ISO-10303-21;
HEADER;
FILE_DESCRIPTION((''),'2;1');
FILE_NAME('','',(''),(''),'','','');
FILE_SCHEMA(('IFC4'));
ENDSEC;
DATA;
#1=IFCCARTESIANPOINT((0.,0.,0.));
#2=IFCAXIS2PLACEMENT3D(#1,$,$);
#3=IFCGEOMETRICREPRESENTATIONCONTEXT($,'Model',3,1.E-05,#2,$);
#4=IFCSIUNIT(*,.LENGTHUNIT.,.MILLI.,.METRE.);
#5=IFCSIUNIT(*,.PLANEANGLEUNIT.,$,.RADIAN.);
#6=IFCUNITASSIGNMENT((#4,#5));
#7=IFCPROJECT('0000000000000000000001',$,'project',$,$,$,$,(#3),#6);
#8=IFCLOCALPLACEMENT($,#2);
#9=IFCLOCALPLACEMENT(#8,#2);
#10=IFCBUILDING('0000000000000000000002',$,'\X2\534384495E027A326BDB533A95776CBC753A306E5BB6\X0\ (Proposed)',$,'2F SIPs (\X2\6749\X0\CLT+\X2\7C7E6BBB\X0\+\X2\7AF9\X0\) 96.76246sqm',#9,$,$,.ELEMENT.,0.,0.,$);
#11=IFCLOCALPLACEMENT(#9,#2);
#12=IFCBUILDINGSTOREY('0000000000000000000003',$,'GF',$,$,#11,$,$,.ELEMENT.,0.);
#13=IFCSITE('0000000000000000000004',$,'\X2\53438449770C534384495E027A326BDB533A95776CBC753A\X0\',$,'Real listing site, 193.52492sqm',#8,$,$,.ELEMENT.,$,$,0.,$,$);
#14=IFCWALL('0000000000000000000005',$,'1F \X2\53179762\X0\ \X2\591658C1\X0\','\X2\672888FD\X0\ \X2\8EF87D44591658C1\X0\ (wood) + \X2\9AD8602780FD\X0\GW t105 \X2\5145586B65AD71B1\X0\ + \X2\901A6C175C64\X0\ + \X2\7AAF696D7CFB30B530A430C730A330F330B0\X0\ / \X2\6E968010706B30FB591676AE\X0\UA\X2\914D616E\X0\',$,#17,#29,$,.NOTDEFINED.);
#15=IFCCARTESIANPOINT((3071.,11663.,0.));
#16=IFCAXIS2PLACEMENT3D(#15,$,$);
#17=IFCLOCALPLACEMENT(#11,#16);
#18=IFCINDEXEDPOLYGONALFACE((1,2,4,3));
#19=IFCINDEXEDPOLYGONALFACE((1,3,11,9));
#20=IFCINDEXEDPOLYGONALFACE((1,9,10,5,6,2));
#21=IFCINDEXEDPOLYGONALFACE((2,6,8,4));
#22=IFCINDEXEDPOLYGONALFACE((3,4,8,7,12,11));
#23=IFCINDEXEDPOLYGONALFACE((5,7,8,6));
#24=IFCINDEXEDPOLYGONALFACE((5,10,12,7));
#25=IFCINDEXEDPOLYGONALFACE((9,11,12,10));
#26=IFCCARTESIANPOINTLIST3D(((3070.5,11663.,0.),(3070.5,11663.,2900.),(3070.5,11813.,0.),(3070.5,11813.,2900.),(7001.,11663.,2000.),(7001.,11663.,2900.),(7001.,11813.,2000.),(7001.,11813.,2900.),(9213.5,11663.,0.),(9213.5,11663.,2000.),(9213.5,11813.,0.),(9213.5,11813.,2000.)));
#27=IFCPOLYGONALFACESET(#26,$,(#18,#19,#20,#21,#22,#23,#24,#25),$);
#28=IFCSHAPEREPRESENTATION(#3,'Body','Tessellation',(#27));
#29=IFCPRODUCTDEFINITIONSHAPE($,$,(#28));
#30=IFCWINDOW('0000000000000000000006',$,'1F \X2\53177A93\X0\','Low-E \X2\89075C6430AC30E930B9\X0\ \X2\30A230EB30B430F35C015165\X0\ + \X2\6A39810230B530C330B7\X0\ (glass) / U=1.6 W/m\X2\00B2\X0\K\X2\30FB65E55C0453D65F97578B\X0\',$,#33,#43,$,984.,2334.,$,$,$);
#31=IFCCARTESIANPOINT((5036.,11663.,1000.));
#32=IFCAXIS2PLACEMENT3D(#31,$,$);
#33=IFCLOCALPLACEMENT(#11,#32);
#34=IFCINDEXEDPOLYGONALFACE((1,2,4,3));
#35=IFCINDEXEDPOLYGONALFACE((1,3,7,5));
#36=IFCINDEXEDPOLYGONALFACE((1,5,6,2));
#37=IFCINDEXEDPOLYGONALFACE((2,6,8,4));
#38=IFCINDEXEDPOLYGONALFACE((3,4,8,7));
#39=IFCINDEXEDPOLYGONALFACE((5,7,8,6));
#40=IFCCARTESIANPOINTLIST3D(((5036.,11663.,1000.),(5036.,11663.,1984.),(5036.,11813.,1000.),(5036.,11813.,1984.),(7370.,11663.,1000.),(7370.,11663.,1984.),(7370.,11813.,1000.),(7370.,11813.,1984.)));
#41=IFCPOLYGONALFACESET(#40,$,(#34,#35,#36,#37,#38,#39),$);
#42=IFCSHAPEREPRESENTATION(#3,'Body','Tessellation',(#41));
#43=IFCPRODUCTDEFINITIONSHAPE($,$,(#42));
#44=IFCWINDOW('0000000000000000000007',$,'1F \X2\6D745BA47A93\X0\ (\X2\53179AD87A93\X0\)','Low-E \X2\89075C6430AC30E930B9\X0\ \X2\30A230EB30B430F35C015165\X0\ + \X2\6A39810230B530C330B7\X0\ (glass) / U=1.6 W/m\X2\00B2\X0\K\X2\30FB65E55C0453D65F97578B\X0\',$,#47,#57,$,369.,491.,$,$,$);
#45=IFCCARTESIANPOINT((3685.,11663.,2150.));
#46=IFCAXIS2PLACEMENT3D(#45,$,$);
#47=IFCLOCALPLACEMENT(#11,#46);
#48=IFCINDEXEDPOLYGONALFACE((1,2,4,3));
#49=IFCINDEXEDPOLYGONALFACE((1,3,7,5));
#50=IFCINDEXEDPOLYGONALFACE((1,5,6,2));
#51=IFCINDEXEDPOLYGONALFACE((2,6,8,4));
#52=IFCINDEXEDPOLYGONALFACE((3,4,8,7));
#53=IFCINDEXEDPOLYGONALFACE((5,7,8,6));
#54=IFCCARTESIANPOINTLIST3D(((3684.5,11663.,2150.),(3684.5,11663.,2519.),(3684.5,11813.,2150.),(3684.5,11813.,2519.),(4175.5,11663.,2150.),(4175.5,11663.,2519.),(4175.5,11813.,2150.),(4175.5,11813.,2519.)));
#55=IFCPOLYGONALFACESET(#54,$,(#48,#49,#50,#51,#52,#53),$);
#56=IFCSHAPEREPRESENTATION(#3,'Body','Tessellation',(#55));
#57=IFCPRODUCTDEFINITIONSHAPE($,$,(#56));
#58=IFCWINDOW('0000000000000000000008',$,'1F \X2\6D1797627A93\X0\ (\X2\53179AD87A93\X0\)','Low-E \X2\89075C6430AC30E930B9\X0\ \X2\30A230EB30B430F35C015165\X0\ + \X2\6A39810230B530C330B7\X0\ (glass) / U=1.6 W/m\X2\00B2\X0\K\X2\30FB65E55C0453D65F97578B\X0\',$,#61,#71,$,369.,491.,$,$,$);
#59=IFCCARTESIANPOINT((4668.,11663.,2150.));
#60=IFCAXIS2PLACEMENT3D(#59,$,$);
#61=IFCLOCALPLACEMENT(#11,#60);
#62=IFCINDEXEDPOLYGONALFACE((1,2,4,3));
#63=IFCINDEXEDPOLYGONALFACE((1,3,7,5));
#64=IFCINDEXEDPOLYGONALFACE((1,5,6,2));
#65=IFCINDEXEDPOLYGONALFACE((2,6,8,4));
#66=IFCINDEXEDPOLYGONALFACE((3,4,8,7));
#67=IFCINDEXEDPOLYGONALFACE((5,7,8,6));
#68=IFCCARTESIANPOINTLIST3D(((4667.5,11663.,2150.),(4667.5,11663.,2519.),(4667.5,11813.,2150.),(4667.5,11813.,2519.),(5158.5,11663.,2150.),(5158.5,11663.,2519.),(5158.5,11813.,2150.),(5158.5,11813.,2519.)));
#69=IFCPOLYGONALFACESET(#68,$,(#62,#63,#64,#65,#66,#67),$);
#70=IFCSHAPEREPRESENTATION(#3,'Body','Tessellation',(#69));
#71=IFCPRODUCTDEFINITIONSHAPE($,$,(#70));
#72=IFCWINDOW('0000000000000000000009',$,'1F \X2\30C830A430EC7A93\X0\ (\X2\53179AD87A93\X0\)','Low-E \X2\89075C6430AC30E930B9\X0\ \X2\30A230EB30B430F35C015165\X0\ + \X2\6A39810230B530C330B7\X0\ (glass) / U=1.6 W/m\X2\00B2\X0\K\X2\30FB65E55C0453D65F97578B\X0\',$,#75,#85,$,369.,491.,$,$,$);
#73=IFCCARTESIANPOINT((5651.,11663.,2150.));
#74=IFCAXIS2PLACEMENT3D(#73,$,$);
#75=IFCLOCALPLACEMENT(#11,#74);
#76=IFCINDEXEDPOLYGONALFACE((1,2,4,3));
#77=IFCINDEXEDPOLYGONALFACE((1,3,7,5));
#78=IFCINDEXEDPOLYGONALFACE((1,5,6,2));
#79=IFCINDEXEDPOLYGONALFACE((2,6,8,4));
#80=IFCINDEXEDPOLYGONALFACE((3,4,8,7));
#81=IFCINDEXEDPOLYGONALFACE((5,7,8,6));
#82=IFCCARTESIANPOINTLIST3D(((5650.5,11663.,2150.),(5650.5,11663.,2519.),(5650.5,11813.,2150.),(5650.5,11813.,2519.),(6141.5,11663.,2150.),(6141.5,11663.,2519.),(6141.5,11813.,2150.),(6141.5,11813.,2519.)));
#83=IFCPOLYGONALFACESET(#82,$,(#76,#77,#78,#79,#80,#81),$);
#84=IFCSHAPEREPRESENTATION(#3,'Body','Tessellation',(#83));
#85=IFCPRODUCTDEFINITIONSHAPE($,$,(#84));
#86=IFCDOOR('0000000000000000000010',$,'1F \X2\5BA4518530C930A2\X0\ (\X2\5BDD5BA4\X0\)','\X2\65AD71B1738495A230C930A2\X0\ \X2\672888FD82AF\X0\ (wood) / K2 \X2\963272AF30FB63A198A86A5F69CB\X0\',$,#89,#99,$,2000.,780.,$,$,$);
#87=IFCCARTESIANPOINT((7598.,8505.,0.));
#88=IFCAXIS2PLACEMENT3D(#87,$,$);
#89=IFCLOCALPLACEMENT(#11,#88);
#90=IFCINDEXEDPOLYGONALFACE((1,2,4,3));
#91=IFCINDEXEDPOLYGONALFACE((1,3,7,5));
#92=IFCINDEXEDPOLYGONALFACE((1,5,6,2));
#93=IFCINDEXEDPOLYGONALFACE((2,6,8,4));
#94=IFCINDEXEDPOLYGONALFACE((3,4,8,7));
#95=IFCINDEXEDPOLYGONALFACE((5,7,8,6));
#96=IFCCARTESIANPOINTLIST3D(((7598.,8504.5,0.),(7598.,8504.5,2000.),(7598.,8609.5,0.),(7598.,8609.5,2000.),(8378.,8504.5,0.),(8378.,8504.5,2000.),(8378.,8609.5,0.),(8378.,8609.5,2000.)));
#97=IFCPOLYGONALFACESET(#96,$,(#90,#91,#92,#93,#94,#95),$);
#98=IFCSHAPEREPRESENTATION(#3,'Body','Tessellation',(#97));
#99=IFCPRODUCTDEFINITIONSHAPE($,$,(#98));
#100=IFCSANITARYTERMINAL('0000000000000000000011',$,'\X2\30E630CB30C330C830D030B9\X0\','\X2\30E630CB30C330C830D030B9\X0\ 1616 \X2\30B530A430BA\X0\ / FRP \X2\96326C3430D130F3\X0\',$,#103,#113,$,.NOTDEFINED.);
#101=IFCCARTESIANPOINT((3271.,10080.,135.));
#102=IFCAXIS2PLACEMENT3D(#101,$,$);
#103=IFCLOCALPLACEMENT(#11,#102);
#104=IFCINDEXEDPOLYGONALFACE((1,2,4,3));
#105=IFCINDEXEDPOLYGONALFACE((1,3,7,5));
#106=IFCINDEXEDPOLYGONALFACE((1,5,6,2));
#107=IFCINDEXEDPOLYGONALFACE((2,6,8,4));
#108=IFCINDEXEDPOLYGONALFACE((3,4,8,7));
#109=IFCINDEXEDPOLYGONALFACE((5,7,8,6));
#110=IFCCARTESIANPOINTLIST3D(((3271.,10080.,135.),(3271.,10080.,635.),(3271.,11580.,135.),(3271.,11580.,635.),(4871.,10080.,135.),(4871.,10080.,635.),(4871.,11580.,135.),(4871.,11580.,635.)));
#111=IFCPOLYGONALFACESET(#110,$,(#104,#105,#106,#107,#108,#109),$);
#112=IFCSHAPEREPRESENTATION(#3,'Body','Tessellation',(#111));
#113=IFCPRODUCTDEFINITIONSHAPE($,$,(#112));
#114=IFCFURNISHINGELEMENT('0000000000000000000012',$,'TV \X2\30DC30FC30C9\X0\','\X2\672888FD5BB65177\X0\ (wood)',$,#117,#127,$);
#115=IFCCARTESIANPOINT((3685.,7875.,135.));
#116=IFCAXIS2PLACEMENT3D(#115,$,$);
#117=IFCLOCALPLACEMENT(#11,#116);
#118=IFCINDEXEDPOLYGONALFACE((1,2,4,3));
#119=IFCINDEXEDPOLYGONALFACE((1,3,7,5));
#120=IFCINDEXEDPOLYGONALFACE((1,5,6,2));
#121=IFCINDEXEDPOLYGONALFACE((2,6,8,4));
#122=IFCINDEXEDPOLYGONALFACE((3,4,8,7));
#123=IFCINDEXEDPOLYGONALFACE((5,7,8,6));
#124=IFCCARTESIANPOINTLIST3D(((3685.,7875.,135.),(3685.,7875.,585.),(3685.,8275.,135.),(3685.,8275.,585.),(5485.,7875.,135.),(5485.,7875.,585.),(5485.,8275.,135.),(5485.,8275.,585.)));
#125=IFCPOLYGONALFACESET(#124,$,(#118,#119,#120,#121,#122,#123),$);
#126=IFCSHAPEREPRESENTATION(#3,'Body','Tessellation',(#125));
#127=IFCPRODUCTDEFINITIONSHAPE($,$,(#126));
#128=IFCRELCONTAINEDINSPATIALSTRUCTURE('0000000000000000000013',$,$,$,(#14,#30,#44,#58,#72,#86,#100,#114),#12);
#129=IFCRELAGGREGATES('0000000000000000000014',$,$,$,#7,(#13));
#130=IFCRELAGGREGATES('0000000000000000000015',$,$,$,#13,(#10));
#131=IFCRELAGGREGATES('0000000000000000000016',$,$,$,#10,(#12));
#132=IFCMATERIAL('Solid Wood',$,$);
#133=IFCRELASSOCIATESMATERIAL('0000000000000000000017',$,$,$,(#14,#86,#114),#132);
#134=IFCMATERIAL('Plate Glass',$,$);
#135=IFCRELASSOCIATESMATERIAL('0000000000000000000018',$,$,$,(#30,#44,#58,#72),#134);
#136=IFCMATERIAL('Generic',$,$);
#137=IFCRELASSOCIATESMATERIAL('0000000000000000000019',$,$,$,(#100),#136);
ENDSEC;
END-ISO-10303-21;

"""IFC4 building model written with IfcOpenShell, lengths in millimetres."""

from ifc_helpers import new_model, si_unit, frame, frame_2d, origin, place, context, project, spatial, rectangle, extrude, material, element, fill, save


model = new_model("IFC4")

# Units and contexts
model_context = context("Model", 3, precision=1e-05, world=origin())
ifc_project = project(units=[si_unit("LENGTHUNIT", "METRE", prefix="MILLI"), si_unit("PLANEANGLEUNIT", "RADIAN")], contexts=[model_context])

# Site, building, storey
site_placement = place(None, origin())
site = spatial("IfcSite", under=ifc_project, at=site_placement, Name="千葉県千葉市稲毛区長沼町", ObjectType="Real listing site, 193.52492sqm", CompositionType="ELEMENT", RefElevation=0.0)
building_placement = place(site_placement, origin())
building = spatial("IfcBuilding", under=site, at=building_placement, Name="千葉市稲毛区長沼町の家 (Proposed)", ObjectType="2F SIPs (杉CLT+籾殻+竹) 96.76246sqm", CompositionType="ELEMENT", ElevationOfRefHeight=0.0, ElevationOfTerrain=0.0)
storey_placement = place(building_placement, origin())
storey = spatial("IfcBuildingStorey", under=building, at=storey_placement, Name="GF", CompositionType="ELEMENT", Elevation=0.0)

# Wall, openings, windows
ifc_material_1 = material(Name="Solid Wood")
wall_1_placement = place(storey_placement, frame((3071.0, 11663.0, 0.0)))
wall_1 = element("IfcWall", 1, at=wall_1_placement, inside=storey, material=ifc_material_1, Name="1F 北面 外壁", Description="木製 軸組外壁 (wood) + 高性能GW t105 充填断熱 + 通気層 + 窯業系サイディング / 準耐火・外皮UA配慮", PredefinedType="NOTDEFINED", context=model_context, shape_type="SweptSolid", body=[
    extrude(rectangle(XDim=6143.0, YDim=150.0, at=frame_2d((3071.0, 75.0))), frame((3071.0, 11663.0, 0.0)), (0.0, 0.0, 1.0), 2900.0),
])
opening_1_placement = place(storey_placement, frame((5036.0, 11663.0, 1000.0)))
opening_1 = element("IfcOpeningElement", 2, at=opening_1_placement, cuts=wall_1, PredefinedType="NOTDEFINED", context=model_context, shape_type="SweptSolid", body=[
    extrude(rectangle(XDim=2334.0, YDim=150.0, at=frame_2d((1167.0, 75.0))), frame((5036.0, 11663.0, 1000.0)), (0.0, 0.0, 1.0), 984.0),
])
opening_2_placement = place(storey_placement, frame((3685.0, 11663.0, 2150.0)))
opening_2 = element("IfcOpeningElement", 3, at=opening_2_placement, cuts=wall_1, PredefinedType="NOTDEFINED", context=model_context, shape_type="SweptSolid", body=[
    extrude(rectangle(XDim=491.0, YDim=150.0, at=frame_2d((245.0, 75.0))), frame((3685.0, 11663.0, 2150.0)), (0.0, 0.0, 1.0), 369.0),
])
opening_3_placement = place(storey_placement, frame((4668.0, 11663.0, 2150.0)))
opening_3 = element("IfcOpeningElement", 4, at=opening_3_placement, cuts=wall_1, PredefinedType="NOTDEFINED", context=model_context, shape_type="SweptSolid", body=[
    extrude(rectangle(XDim=491.0, YDim=150.0, at=frame_2d((245.0, 75.0))), frame((4668.0, 11663.0, 2150.0)), (0.0, 0.0, 1.0), 369.0),
])
opening_4_placement = place(storey_placement, frame((5651.0, 11663.0, 2150.0)))
opening_4 = element("IfcOpeningElement", 5, at=opening_4_placement, cuts=wall_1, PredefinedType="NOTDEFINED", context=model_context, shape_type="SweptSolid", body=[
    extrude(rectangle(XDim=491.0, YDim=150.0, at=frame_2d((245.0, 75.0))), frame((5651.0, 11663.0, 2150.0)), (0.0, 0.0, 1.0), 369.0),
])
ifc_material_2 = material(Name="Plate Glass")
window_1_placement = place(storey_placement, frame((5036.0, 11663.0, 1000.0)))
window_1 = element("IfcWindow", 6, at=window_1_placement, inside=storey, material=ifc_material_2, Name="1F 北窓", Description="Low-E 複層ガラス アルゴン封入 + 樹脂サッシ (glass) / U=1.6 W/m²K・日射取得型", OverallHeight=984.0, OverallWidth=2334.0, context=model_context, shape_type="SweptSolid", body=[
    extrude(rectangle(XDim=2334.0, YDim=150.0, at=frame_2d((1167.0, 75.0))), frame((5036.0, 11663.0, 1000.0)), (0.0, 0.0, 1.0), 984.0),
])
fill(opening_1, window_1)
window_2_placement = place(storey_placement, frame((3685.0, 11663.0, 2150.0)))
window_2 = element("IfcWindow", 7, at=window_2_placement, inside=storey, material=ifc_material_2, Name="1F 浴室窓 (北高窓)", Description="Low-E 複層ガラス アルゴン封入 + 樹脂サッシ (glass) / U=1.6 W/m²K・日射取得型", OverallHeight=369.0, OverallWidth=491.0, context=model_context, shape_type="SweptSolid", body=[
    extrude(rectangle(XDim=491.0, YDim=150.0, at=frame_2d((245.0, 75.0))), frame((3685.0, 11663.0, 2150.0)), (0.0, 0.0, 1.0), 369.0),
])
fill(opening_2, window_2)
window_3_placement = place(storey_placement, frame((4668.0, 11663.0, 2150.0)))
window_3 = element("IfcWindow", 8, at=window_3_placement, inside=storey, material=ifc_material_2, Name="1F 洗面窓 (北高窓)", Description="Low-E 複層ガラス アルゴン封入 + 樹脂サッシ (glass) / U=1.6 W/m²K・日射取得型", OverallHeight=369.0, OverallWidth=491.0, context=model_context, shape_type="SweptSolid", body=[
    extrude(rectangle(XDim=491.0, YDim=150.0, at=frame_2d((245.0, 75.0))), frame((4668.0, 11663.0, 2150.0)), (0.0, 0.0, 1.0), 369.0),
])
fill(opening_3, window_3)
window_4_placement = place(storey_placement, frame((5651.0, 11663.0, 2150.0)))
window_4 = element("IfcWindow", 9, at=window_4_placement, inside=storey, material=ifc_material_2, Name="1F トイレ窓 (北高窓)", Description="Low-E 複層ガラス アルゴン封入 + 樹脂サッシ (glass) / U=1.6 W/m²K・日射取得型", OverallHeight=369.0, OverallWidth=491.0, context=model_context, shape_type="SweptSolid", body=[
    extrude(rectangle(XDim=491.0, YDim=150.0, at=frame_2d((245.0, 75.0))), frame((5651.0, 11663.0, 2150.0)), (0.0, 0.0, 1.0), 369.0),
])
fill(opening_4, window_4)

# Door
door_1_placement = place(storey_placement, frame((7598.0, 8505.0, 0.0)))
element("IfcDoor", 10, at=door_1_placement, inside=storey, material=ifc_material_1, Name="1F 室内ドア (寝室)", Description="断熱玄関ドア 木製芯 (wood) / K2 防犯・採風機構", OverallHeight=2000.0, OverallWidth=780.0, context=model_context, shape_type="SweptSolid", body=[
    extrude(rectangle(XDim=780.0, YDim=105.0, at=frame_2d((390.0, 52.0))), frame((7598.0, 8505.0, 0.0)), (0.0, 0.0, 1.0), 2000.0),
])

# Sanitary terminal
ifc_material_3 = material(Name="Generic")
sanitary_terminal_placement = place(storey_placement, frame((3271.0, 10080.0, 135.0)))
element("IfcSanitaryTerminal", 11, at=sanitary_terminal_placement, inside=storey, material=ifc_material_3, Name="ユニットバス", Description="ユニットバス 1616 サイズ / FRP 防水パン", PredefinedType="NOTDEFINED", context=model_context, shape_type="SweptSolid", body=[
    extrude(rectangle(XDim=1600.0, YDim=1500.0, at=frame_2d((800.0, 750.0))), frame((3271.0, 10080.0, 135.0)), (0.0, 0.0, 1.0), 500.0),
])

# Furnishing element
furnishing_placement = place(storey_placement, frame((3685.0, 7875.0, 135.0)))
element("IfcFurnishingElement", 12, at=furnishing_placement, inside=storey, material=ifc_material_1, Name="TV ボード", Description="木製家具 (wood)", context=model_context, shape_type="SweptSolid", body=[
    extrude(rectangle(XDim=1800.0, YDim=400.0, at=frame_2d((900.0, 200.0))), frame((3685.0, 7875.0, 135.0)), (0.0, 0.0, 1.0), 450.0),
])

save(model, "model.ifc")
